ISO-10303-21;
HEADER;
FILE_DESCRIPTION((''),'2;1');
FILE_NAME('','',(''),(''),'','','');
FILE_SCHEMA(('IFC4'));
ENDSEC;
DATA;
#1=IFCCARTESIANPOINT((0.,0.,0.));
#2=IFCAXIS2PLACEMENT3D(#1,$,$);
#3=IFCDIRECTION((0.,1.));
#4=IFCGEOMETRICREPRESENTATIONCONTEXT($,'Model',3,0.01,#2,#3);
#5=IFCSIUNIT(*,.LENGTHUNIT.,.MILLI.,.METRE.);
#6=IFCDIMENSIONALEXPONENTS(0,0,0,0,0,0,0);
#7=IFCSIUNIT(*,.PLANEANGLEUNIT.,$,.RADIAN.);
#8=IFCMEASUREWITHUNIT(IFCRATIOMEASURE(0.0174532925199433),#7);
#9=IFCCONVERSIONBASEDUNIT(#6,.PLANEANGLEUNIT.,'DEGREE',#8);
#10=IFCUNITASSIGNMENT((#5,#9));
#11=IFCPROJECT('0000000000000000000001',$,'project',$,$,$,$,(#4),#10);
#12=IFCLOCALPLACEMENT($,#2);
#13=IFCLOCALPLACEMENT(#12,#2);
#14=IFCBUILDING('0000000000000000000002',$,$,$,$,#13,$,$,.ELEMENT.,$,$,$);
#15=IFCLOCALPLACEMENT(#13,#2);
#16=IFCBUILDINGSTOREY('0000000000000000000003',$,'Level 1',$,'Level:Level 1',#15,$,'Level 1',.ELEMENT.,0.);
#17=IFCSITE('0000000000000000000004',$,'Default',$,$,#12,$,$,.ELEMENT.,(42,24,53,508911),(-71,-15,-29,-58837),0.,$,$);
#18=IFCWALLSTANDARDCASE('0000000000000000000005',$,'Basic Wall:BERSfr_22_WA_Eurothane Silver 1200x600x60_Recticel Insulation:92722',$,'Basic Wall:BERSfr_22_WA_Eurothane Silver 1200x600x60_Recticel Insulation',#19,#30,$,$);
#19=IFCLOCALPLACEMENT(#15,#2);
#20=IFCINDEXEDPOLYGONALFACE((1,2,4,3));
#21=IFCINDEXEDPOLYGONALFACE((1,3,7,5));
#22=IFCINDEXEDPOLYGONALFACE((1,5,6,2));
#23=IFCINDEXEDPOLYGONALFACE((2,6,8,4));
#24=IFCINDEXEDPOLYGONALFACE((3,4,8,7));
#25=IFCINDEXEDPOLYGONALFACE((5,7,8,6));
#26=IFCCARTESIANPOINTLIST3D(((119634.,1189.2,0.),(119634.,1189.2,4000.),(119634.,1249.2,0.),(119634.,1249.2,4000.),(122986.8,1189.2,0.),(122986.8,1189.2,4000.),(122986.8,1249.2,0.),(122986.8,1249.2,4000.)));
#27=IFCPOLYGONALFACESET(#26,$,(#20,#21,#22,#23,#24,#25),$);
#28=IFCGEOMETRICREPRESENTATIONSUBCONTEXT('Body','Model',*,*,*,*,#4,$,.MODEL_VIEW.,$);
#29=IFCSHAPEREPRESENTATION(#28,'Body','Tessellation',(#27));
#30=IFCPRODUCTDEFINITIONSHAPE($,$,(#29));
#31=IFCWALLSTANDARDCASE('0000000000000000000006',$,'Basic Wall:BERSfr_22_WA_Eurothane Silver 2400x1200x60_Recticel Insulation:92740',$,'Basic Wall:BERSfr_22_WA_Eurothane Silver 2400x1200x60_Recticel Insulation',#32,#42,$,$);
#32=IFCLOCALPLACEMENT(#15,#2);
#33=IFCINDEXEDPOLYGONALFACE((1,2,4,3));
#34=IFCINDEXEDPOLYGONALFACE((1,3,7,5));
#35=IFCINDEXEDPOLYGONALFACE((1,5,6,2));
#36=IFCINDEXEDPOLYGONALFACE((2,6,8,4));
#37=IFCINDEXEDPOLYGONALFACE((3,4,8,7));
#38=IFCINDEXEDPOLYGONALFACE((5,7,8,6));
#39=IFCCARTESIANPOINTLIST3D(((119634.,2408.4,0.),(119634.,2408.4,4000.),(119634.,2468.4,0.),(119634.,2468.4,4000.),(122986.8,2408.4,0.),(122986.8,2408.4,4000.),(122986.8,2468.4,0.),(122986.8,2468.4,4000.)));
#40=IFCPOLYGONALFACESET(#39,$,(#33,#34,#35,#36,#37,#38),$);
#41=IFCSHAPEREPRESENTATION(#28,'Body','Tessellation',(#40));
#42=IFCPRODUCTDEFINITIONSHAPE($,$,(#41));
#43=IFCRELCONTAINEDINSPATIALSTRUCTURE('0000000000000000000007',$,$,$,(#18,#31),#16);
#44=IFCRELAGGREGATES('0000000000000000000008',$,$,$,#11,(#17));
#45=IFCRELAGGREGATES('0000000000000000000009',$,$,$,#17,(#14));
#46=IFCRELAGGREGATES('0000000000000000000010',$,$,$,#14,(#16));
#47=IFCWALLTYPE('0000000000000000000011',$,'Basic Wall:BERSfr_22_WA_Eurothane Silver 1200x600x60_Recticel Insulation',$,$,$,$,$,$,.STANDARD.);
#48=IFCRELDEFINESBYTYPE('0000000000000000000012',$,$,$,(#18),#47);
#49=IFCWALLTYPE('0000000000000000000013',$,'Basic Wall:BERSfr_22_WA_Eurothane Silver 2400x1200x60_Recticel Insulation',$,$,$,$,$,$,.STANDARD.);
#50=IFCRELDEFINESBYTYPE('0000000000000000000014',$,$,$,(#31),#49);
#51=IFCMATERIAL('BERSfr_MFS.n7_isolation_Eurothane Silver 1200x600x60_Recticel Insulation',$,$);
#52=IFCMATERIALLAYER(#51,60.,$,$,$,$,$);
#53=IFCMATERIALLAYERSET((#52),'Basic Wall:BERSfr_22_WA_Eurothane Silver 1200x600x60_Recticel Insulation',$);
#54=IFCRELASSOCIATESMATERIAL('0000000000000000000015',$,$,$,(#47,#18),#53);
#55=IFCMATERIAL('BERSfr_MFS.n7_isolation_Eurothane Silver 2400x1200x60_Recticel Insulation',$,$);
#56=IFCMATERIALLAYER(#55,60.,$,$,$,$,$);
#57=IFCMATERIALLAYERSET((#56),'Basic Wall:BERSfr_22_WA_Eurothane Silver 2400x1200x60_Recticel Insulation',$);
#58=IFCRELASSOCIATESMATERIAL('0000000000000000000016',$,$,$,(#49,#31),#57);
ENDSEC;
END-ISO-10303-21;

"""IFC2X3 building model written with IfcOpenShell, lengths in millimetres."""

from ifc_helpers import new_model, entity, si_unit, converted_unit, direction, frame, frame_2d, origin, place, context, subcontext, project, spatial, rectangle, extrude, material, layer, layer_set, layer_usage, type_object, element, save


model = new_model("IFC2X3")

# Units and contexts
model_context = context("Model", 3, precision=0.01, world=origin(), true_north=direction((0.0, 1.0)))
body_context = subcontext(model_context, "Body", "Model", "MODEL_VIEW")
ifc_project = project(units=[si_unit("LENGTHUNIT", "METRE", prefix="MILLI"), converted_unit("PLANEANGLEUNIT", "DEGREE", entity("IfcRatioMeasure", 0.0174532925199433), si_unit("PLANEANGLEUNIT", "RADIAN"), dimensions=[0, 0, 0, 0, 0, 0, 0])], contexts=[model_context])

# Site, building, storey
site_placement = place(None, origin())
site = spatial("IfcSite", under=ifc_project, at=site_placement, Name="Default", CompositionType="ELEMENT", RefLatitude=(42, 24, 53, 508911), RefLongitude=(-71, -15, -29, -58837), RefElevation=0.0)
building_placement = place(site_placement, origin())
building = spatial("IfcBuilding", under=site, at=building_placement, CompositionType="ELEMENT")
storey_placement = place(building_placement, origin())
storey = spatial("IfcBuildingStorey", under=building, at=storey_placement, Name="Level 1", ObjectType="Level:Level 1", LongName="Level 1", CompositionType="ELEMENT", Elevation=0.0)

# Shared definitions
ifc_material_1 = material(Name="BERSfr_MFS.n7_isolation_Eurothane Silver 1200x600x60_Recticel Insulation")

# Walls
ifc_layer_1 = layer(ifc_material_1, 60.0)
ifc_layer_set_1 = layer_set([ifc_layer_1], Name="Basic Wall:BERSfr_22_WA_Eurothane Silver 1200x600x60_Recticel Insulation")
ifc_layer_usage_1 = layer_usage(ifc_layer_set_1, "AXIS2", "NEGATIVE", 30.0)
wall_type_1 = type_object("IfcWallType", Name="Basic Wall:BERSfr_22_WA_Eurothane Silver 1200x600x60_Recticel Insulation", PredefinedType="STANDARD", material=ifc_layer_set_1)
wall_1_placement = place(storey_placement, frame((119634.0, 1219.2, 0.0)))
element("IfcWallStandardCase", 1, at=wall_1_placement, inside=storey, type_object=wall_type_1, material=ifc_layer_usage_1, Name="Basic Wall:BERSfr_22_WA_Eurothane Silver 1200x600x60_Recticel Insulation:92722", ObjectType="Basic Wall:BERSfr_22_WA_Eurothane Silver 1200x600x60_Recticel Insulation", context=body_context, shape_type="SweptSolid", body=[
    extrude(rectangle(XDim=3352.8, YDim=60.0, at=frame_2d((1676.4, 0.0), x_axis=(-1.0, 0.0))), origin(), (0.0, 0.0, 1.0), 4000.0),
])
ifc_material_2 = material(Name="BERSfr_MFS.n7_isolation_Eurothane Silver 2400x1200x60_Recticel Insulation")
ifc_layer_2 = layer(ifc_material_2, 60.0)
ifc_layer_set_2 = layer_set([ifc_layer_2], Name="Basic Wall:BERSfr_22_WA_Eurothane Silver 2400x1200x60_Recticel Insulation")
ifc_layer_usage_2 = layer_usage(ifc_layer_set_2, "AXIS2", "NEGATIVE", 30.0)
wall_type_2 = type_object("IfcWallType", Name="Basic Wall:BERSfr_22_WA_Eurothane Silver 2400x1200x60_Recticel Insulation", PredefinedType="STANDARD", material=ifc_layer_set_2)
wall_2_placement = place(storey_placement, frame((119634.0, 2438.4, 0.0)))
element("IfcWallStandardCase", 2, at=wall_2_placement, inside=storey, type_object=wall_type_2, material=ifc_layer_usage_2, Name="Basic Wall:BERSfr_22_WA_Eurothane Silver 2400x1200x60_Recticel Insulation:92740", ObjectType="Basic Wall:BERSfr_22_WA_Eurothane Silver 2400x1200x60_Recticel Insulation", context=body_context, shape_type="SweptSolid", body=[
    extrude(rectangle(XDim=3352.8, YDim=60.0, at=frame_2d((1676.4, 0.0), x_axis=(-1.0, 0.0))), origin(), (0.0, 0.0, 1.0), 4000.0),
])

save(model, "model.ifc")
